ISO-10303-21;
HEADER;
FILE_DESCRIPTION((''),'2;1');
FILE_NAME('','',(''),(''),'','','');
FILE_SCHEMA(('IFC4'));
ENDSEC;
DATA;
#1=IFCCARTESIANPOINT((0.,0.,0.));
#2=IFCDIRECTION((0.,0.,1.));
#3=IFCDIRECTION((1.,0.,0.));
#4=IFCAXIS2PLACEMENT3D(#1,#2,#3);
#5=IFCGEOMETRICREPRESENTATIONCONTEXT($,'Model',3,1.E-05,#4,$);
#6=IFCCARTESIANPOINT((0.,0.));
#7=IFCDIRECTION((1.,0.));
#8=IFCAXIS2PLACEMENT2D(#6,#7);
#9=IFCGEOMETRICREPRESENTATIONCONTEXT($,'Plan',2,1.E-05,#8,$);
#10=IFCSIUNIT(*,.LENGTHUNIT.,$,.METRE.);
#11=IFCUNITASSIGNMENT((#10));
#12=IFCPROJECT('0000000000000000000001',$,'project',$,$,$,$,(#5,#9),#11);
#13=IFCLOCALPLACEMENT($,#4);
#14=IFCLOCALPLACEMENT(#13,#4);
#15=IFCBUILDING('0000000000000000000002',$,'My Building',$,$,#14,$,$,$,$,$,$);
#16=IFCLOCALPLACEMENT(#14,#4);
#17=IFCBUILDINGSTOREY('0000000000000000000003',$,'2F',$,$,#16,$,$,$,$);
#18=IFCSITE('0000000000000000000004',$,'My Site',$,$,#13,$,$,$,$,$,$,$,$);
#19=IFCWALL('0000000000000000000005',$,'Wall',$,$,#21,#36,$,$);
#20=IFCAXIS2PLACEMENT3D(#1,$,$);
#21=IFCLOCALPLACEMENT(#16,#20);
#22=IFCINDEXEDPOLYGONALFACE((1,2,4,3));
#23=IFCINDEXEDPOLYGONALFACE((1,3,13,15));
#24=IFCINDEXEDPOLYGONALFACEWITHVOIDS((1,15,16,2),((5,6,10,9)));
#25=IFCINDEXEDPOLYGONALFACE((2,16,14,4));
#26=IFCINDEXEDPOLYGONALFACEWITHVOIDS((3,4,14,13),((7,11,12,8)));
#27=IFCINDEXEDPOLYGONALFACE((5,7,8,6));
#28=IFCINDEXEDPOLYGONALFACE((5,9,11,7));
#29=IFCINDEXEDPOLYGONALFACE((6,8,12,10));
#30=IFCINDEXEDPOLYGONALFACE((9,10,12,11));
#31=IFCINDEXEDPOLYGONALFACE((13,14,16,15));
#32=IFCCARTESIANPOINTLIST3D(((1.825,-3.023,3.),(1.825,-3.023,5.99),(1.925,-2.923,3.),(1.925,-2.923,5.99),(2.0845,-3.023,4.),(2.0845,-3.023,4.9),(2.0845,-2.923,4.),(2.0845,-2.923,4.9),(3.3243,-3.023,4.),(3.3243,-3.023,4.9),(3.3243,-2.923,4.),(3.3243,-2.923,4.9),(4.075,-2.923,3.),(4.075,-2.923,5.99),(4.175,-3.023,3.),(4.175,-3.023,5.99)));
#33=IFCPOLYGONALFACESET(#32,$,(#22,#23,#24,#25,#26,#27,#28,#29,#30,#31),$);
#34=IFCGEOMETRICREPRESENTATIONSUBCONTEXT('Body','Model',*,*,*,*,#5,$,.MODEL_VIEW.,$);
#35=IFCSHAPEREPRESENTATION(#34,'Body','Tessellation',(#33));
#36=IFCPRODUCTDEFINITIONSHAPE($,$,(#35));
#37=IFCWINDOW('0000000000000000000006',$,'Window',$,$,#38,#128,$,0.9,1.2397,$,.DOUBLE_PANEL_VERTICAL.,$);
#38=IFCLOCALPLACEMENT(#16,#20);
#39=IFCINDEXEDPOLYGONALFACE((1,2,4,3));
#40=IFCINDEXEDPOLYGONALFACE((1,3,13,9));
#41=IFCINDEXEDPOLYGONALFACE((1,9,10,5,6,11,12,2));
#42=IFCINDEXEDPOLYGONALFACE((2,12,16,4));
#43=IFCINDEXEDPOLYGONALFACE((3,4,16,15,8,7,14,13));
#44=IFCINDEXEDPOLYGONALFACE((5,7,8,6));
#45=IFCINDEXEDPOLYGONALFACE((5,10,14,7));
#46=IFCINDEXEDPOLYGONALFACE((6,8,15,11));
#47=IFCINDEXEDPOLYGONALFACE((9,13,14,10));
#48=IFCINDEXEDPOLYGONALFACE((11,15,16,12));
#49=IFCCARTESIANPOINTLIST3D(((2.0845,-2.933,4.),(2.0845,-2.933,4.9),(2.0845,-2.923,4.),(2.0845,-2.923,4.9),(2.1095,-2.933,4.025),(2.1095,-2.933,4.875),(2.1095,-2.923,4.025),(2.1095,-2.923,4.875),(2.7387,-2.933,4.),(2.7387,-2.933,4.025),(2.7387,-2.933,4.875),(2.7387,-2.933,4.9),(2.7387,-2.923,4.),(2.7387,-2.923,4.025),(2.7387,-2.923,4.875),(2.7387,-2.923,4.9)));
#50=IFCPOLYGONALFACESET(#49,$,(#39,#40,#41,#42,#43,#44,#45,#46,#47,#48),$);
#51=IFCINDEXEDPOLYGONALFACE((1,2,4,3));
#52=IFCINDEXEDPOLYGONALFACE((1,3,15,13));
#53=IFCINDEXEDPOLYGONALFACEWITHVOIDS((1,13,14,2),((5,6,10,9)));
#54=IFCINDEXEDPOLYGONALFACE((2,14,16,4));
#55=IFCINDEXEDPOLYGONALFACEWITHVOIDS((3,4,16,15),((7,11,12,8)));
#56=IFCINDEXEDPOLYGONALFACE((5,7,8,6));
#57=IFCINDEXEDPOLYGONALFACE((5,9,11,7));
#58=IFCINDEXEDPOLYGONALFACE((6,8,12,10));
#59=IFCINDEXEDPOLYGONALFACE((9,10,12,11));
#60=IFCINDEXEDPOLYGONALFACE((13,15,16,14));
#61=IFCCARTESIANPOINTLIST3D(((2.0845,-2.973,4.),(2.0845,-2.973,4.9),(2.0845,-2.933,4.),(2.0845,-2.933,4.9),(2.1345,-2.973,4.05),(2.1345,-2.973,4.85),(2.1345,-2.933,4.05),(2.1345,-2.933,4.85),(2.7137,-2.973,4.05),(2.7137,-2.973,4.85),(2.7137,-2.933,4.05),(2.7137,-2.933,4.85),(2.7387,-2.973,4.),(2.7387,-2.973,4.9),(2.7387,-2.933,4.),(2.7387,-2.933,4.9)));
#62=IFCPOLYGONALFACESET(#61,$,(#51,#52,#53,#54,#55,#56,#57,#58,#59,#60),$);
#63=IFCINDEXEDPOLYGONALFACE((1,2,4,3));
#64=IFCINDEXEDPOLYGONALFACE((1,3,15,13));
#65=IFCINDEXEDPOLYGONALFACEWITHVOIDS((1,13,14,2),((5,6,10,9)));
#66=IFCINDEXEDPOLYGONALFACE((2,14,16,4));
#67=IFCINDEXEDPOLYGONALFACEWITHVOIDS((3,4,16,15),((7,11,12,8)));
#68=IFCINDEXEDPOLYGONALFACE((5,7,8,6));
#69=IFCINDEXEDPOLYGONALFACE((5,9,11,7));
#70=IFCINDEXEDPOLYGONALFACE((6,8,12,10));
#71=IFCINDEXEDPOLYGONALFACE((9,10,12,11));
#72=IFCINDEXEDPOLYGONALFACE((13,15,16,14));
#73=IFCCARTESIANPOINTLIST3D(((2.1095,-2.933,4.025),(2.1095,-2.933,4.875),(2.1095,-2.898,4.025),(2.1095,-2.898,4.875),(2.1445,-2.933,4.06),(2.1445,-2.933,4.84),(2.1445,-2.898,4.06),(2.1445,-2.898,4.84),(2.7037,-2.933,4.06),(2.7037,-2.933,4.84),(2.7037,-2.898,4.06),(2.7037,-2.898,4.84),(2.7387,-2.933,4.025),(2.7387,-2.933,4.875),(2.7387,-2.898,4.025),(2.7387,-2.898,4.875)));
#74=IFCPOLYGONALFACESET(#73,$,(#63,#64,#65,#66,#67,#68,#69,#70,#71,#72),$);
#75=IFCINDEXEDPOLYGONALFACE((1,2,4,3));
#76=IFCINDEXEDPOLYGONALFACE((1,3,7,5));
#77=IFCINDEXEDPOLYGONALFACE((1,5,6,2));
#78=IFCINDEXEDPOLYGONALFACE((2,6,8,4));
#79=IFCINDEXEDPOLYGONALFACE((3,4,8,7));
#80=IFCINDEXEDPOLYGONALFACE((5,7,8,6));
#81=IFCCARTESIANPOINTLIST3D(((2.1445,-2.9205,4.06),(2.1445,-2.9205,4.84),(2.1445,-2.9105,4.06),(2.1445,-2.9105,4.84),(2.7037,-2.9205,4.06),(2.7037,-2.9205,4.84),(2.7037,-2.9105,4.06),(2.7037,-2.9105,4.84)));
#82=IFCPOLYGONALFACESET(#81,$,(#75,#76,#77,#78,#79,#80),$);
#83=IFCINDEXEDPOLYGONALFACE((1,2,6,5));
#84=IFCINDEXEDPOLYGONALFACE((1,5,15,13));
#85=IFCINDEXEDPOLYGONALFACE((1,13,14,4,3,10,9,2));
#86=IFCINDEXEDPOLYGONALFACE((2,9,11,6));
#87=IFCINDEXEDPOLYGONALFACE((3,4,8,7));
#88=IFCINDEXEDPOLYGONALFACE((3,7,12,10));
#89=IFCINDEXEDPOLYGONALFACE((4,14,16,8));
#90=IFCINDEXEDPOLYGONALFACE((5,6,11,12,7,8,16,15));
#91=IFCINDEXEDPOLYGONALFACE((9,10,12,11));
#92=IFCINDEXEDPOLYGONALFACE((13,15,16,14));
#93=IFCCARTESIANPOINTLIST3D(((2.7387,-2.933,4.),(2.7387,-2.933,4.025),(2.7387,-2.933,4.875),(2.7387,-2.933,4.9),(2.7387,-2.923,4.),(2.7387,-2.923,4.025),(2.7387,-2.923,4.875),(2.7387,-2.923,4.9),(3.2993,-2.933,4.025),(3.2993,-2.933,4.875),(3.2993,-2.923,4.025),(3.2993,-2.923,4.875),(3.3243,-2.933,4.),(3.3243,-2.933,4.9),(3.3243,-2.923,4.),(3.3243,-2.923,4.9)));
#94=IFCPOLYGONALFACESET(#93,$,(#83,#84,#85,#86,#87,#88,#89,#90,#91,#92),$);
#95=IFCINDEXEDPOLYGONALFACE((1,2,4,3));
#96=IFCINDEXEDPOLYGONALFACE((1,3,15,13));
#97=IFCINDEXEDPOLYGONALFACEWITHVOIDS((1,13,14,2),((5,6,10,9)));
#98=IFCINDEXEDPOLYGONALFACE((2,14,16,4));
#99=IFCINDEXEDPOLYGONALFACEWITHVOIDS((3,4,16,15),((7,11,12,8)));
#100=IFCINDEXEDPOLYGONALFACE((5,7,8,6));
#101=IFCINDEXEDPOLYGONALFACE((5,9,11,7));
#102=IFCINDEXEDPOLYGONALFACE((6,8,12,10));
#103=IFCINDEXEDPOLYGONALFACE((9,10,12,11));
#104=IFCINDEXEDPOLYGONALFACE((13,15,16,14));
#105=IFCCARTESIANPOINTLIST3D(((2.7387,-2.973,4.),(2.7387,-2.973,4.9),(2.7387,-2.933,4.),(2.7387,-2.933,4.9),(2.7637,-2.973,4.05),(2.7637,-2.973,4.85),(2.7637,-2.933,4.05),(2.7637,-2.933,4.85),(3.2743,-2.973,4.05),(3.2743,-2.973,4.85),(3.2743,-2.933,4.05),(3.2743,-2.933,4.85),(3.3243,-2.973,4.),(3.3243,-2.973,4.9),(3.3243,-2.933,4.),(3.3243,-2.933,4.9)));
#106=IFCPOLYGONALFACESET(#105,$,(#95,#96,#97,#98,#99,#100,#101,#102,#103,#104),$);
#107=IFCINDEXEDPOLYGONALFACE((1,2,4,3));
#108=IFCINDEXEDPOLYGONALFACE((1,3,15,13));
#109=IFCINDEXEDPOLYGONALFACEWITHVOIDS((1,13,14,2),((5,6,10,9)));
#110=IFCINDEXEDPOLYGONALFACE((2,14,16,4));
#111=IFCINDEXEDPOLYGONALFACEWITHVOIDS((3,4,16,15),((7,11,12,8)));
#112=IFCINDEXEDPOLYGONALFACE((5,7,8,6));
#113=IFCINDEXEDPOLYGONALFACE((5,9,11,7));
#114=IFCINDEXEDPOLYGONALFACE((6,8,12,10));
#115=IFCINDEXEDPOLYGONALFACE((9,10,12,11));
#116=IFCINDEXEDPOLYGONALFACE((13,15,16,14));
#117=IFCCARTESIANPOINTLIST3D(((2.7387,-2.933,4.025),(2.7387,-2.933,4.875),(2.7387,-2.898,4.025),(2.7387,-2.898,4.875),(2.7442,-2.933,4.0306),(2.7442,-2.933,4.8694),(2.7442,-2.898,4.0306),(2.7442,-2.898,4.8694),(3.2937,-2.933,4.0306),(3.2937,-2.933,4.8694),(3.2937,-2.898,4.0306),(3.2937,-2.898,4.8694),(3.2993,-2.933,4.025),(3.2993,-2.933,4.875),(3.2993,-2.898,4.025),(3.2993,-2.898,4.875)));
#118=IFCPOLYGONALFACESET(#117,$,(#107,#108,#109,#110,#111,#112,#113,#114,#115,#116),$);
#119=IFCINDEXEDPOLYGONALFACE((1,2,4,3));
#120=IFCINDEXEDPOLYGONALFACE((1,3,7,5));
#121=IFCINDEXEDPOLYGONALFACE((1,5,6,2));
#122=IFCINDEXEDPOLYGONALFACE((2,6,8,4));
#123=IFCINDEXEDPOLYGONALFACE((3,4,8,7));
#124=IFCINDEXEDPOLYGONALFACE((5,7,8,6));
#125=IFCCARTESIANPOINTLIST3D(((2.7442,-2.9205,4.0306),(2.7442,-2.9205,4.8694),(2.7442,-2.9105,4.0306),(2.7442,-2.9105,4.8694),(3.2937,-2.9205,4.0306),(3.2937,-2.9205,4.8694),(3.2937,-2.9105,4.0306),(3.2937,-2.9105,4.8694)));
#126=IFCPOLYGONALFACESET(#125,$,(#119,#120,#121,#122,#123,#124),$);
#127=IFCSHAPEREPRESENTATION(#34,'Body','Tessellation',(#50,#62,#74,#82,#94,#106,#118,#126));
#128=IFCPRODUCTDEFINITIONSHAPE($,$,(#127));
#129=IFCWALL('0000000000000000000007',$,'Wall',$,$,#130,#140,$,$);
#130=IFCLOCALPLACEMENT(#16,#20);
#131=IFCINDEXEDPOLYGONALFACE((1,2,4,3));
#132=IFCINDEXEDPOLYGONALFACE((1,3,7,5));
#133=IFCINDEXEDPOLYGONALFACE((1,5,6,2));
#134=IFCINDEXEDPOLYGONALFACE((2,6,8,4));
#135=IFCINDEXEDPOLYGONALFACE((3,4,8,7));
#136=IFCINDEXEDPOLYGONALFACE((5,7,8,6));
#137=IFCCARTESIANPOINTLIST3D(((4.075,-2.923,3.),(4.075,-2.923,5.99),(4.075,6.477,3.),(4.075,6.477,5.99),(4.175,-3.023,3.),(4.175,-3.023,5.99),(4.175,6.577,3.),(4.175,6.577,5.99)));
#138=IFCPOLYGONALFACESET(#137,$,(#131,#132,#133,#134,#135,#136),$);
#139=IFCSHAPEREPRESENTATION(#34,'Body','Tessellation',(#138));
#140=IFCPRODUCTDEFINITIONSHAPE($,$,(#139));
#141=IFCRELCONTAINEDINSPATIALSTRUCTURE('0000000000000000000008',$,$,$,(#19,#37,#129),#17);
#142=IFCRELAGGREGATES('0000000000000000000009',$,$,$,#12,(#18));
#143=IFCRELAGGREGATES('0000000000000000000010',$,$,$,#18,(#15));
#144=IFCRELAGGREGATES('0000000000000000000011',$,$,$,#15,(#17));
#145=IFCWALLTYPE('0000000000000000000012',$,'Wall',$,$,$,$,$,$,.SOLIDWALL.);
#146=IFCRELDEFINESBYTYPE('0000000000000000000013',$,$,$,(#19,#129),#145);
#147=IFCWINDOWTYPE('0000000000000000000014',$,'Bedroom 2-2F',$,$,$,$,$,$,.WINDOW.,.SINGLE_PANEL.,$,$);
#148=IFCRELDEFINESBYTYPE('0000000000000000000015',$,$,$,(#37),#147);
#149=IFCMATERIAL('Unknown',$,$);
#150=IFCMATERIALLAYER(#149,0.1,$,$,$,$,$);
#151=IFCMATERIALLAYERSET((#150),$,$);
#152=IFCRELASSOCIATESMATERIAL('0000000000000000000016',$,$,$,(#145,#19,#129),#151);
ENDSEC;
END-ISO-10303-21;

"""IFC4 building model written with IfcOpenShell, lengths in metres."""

from ifc_helpers import new_model, entity, si_unit, frame, origin_with_axes, origin_2d_with_axis, place, context, subcontext, project, spatial, line, indexed_curve, outline, extrude, shape, source, transform, mapped, material, layer, layer_set, layer_usage, type_object, type_shapes, element, fill, save


model = new_model("IFC4")

# Units and contexts
model_context = context("Model", 3, precision=1e-05, world=origin_with_axes())
plan_context = context("Plan", 2, precision=1e-05, world=origin_2d_with_axis())
body_context_1 = subcontext(model_context, "Body", "Model", "MODEL_VIEW")
body_context_2 = subcontext(plan_context, "Body", "Plan", "PLAN_VIEW")
ifc_project = project(units=[si_unit("LENGTHUNIT", "METRE")], contexts=[model_context, plan_context])

# Site, building, storey
site_placement = place(None, origin_with_axes())
site = spatial("IfcSite", under=ifc_project, at=site_placement, Name="My Site")
building_placement = place(site_placement, origin_with_axes())
building = spatial("IfcBuilding", under=site, at=building_placement, Name="My Building")
storey_placement = place(building_placement, origin_with_axes())
storey = spatial("IfcBuildingStorey", under=building, at=storey_placement, Name="2F")

# Shared definitions
ifc_material = material(Name="Unknown")

# Shared definitions
ifc_layer_1 = layer(ifc_material, 0.1)
ifc_layer_set_1 = layer_set([ifc_layer_1])
wall_type = type_object("IfcWallType", Name="Wall", PredefinedType="SOLIDWALL", material=ifc_layer_set_1)

# Wall, opening, window
ifc_layer_usage_1 = layer_usage(ifc_layer_set_1, "AXIS2", "POSITIVE", 0.0)
wall_1_placement = place(storey_placement, frame((1.825, -3.023, 3.0), z_axis=(0.0, 0.0, 1.0), x_axis=(1.0, 0.0, 0.0)))
wall_1 = element("IfcWall", 1, at=wall_1_placement, inside=storey, type_object=wall_type, material=ifc_layer_usage_1, Name="Wall", context=body_context_1, shape_type="SweptSolid", body=[
    extrude(outline(indexed_curve([(0.0, 0.0), (0.1, 0.1), (2.25, 0.1), (2.35, 0.0)], segments=[line(1, 2, 3, 4, 1)])), origin_with_axes(), (0.0, 0.0, 1.0), 2.99),
])
shared_shape_1 = source(origin_with_axes(), body_context_1, "Body", "SweptSolid", [
    extrude(outline(indexed_curve([(0.0, 0.0), (1.2397, 0.0), (1.2397, 0.9), (0.0, 0.9)], segments=[line(1, 2, 3, 4, 1)])), frame((0.0, -0.6, 0.0), z_axis=(0.0, -1.0, 0.0), x_axis=(1.0, 0.0, 0.0)), (0.0, 0.0, -1.0), 1.2),
])
opening_1_placement = place(wall_1_placement, frame((0.2595, 0.0, 1.0), z_axis=(0.0, 0.0, 1.0), x_axis=(1.0, 0.0, 0.0)))
opening_1 = element("IfcOpeningElement", 2, at=opening_1_placement, cuts=wall_1, PredefinedType="OPENING", context=body_context_1, shape_type="MappedRepresentation", body=[
    mapped(shared_shape_1, transform((0.0, 0.0, 0.0), x_axis=(1.0, 0.0, 0.0), y_axis=(0.0, 1.0, 0.0), z_axis=(0.0, 0.0, 1.0), scale=1.0)),
])
window_type = type_object("IfcWindowType", Name="Bedroom 2-2F", PartitioningType="SINGLE_PANEL", PredefinedType="WINDOW")
shared_shape_2 = source(origin_with_axes(), body_context_1, "Body", "SweptSolid", [
    extrude(outline(indexed_curve([(0.6541, 0.0), (0.0, 0.0), (0.0, 0.9), (0.6541, 0.9), (0.6541, 0.875), (0.025, 0.875), (0.025, 0.025), (0.6541, 0.025)], segments=[line(1, 2, 3, 4, 5, 6, 7, 8, 1)])), frame((0.0, 0.09, 0.0), z_axis=(0.0, -1.0, 0.0), x_axis=(1.0, 0.0, 0.0)), (0.0, 0.0, -1.0), 0.01),
    extrude(outline(indexed_curve([(0.0, 0.0), (0.6541, 0.0), (0.6541, 0.9), (0.0, 0.9)], segments=[line(1, 2, 3, 4, 1)]), holes=[indexed_curve([(0.05, 0.05), (0.6291, 0.05), (0.6291, 0.85), (0.05, 0.85)], segments=[line(1, 2, 3, 4, 1)])]), frame((0.0, 0.05, 0.0), z_axis=(0.0, -1.0, 0.0), x_axis=(1.0, 0.0, 0.0)), (0.0, 0.0, -1.0), 0.04),
    extrude(outline(indexed_curve([(0.0, 0.0), (0.6291, 0.0), (0.6291, 0.85), (0.0, 0.85)], segments=[line(1, 2, 3, 4, 1)]), holes=[indexed_curve([(0.035, 0.035), (0.5941, 0.035), (0.5941, 0.815), (0.035, 0.815)], segments=[line(1, 2, 3, 4, 1)])]), frame((0.025, 0.09, 0.025), z_axis=(0.0, -1.0, 0.0), x_axis=(1.0, 0.0, 0.0)), (0.0, 0.0, -1.0), 0.035),
    extrude(outline(indexed_curve([(0.035, 0.035), (0.5941, 0.035), (0.5941, 0.815), (0.035, 0.815)], segments=[line(1, 2, 3, 4, 1)])), frame((0.025, 0.1025, 0.025), z_axis=(0.0, -1.0, 0.0), x_axis=(1.0, 0.0, 0.0)), (0.0, 0.0, -1.0), 0.01),
    extrude(outline(indexed_curve([(0.0, 0.9), (0.5856, 0.9), (0.5856, 0.0), (0.0, 0.0), (0.0, 0.025), (0.5606, 0.025), (0.5606, 0.875), (0.0, 0.875)], segments=[line(1, 2, 3, 4, 5, 6, 7, 8, 1)])), frame((0.6541, 0.09, 0.0), z_axis=(0.0, -1.0, 0.0), x_axis=(1.0, 0.0, 0.0)), (0.0, 0.0, -1.0), 0.01),
    extrude(outline(indexed_curve([(0.0, 0.0), (0.5856, 0.0), (0.5856, 0.9), (0.0, 0.9)], segments=[line(1, 2, 3, 4, 1)]), holes=[indexed_curve([(0.025, 0.05), (0.5356, 0.05), (0.5356, 0.85), (0.025, 0.85)], segments=[line(1, 2, 3, 4, 1)])]), frame((0.6541, 0.05, 0.0), z_axis=(0.0, -1.0, 0.0), x_axis=(1.0, 0.0, 0.0)), (0.0, 0.0, -1.0), 0.04),
    extrude(outline(indexed_curve([(0.0, 0.0), (0.5606, 0.0), (0.5606, 0.85), (0.0, 0.85)], segments=[line(1, 2, 3, 4, 1)]), holes=[indexed_curve([(0.0056, 0.0056), (0.555, 0.0056), (0.555, 0.8444), (0.0056, 0.8444)], segments=[line(1, 2, 3, 4, 1)])]), frame((0.6541, 0.09, 0.025), z_axis=(0.0, -1.0, 0.0), x_axis=(1.0, 0.0, 0.0)), (0.0, 0.0, -1.0), 0.035),
    extrude(outline(indexed_curve([(0.0056, 0.0056), (0.555, 0.0056), (0.555, 0.8444), (0.0056, 0.8444)], segments=[line(1, 2, 3, 4, 1)])), frame((0.6541, 0.1025, 0.025), z_axis=(0.0, -1.0, 0.0), x_axis=(1.0, 0.0, 0.0)), (0.0, 0.0, -1.0), 0.01),
])
shared_shape_3 = source(origin_with_axes(), body_context_2, "Body", "Curve2D", [
    entity("IfcIndexedPolyCurve", entity("IfcCartesianPointList2D", [[0.05, 0.05], [0.6291, 0.05]])),
    entity("IfcIndexedPolyCurve", entity("IfcCartesianPointList2D", [[0.0, 0.1], [0.025, 0.1], [0.025, 0.09], [0.05, 0.09], [0.05, 0.05], [0.0, 0.05]]), [entity("IfcLineIndex", [1, 2, 3, 4, 5, 6, 1])]),
    entity("IfcIndexedPolyCurve", entity("IfcCartesianPointList2D", [[0.6541, 0.1], [0.6541, 0.1], [0.6541, 0.09], [0.6291, 0.09], [0.6291, 0.05], [0.6541, 0.05]])),
    entity("IfcIndexedPolyCurve", entity("IfcCartesianPointList2D", [[0.025, 0.09], [0.06, 0.09], [0.06, 0.125], [0.025, 0.125]]), [entity("IfcLineIndex", [1, 2, 3, 4, 1])]),
    entity("IfcIndexedPolyCurve", entity("IfcCartesianPointList2D", [[0.6541, 0.09], [0.6191, 0.09], [0.6191, 0.125], [0.6541, 0.125]]), [entity("IfcLineIndex", [1, 2, 3, 4, 1])]),
    entity("IfcIndexedPolyCurve", entity("IfcCartesianPointList2D", [[0.06, 0.09], [0.6191, 0.09]])),
    entity("IfcIndexedPolyCurve", entity("IfcCartesianPointList2D", [[0.06, 0.125], [0.6191, 0.125]])),
    entity("IfcIndexedPolyCurve", entity("IfcCartesianPointList2D", [[0.06, 0.1075], [0.6191, 0.1075]])),
    entity("IfcIndexedPolyCurve", entity("IfcCartesianPointList2D", [[0.6791, 0.05], [1.1897, 0.05]])),
    entity("IfcIndexedPolyCurve", entity("IfcCartesianPointList2D", [[0.6541, 0.1], [0.6541, 0.1], [0.6541, 0.09], [0.6791, 0.09], [0.6791, 0.05], [0.6541, 0.05]])),
    entity("IfcIndexedPolyCurve", entity("IfcCartesianPointList2D", [[1.2397, 0.1], [1.2147, 0.1], [1.2147, 0.09], [1.1897, 0.09], [1.1897, 0.05], [1.2397, 0.05]]), [entity("IfcLineIndex", [1, 2, 3, 4, 5, 6, 1])]),
    entity("IfcIndexedPolyCurve", entity("IfcCartesianPointList2D", [[0.6541, 0.09], [0.6597, 0.09], [0.6597, 0.125], [0.6541, 0.125]]), [entity("IfcLineIndex", [1, 2, 3, 4, 1])]),
    entity("IfcIndexedPolyCurve", entity("IfcCartesianPointList2D", [[1.2147, 0.09], [1.2092, 0.09], [1.2092, 0.125], [1.2147, 0.125]]), [entity("IfcLineIndex", [1, 2, 3, 4, 1])]),
    entity("IfcIndexedPolyCurve", entity("IfcCartesianPointList2D", [[0.6597, 0.09], [1.2092, 0.09]])),
    entity("IfcIndexedPolyCurve", entity("IfcCartesianPointList2D", [[0.6597, 0.125], [1.2092, 0.125]])),
    entity("IfcIndexedPolyCurve", entity("IfcCartesianPointList2D", [[0.6597, 0.1075], [1.2092, 0.1075]])),
])
type_shapes(window_type, [shared_shape_2, shared_shape_3])
window_placement = place(opening_1_placement, frame((0.0, 0.0, 0.0), z_axis=(0.0, 0.0, 1.0), x_axis=(1.0, 0.0, 0.0)))
window = element("IfcWindow", 3, at=window_placement, inside=storey, type_object=window_type, Name="Window", OverallHeight=0.9, OverallWidth=1.2397, PartitioningType="DOUBLE_PANEL_VERTICAL", shapes=[
    shape(body_context_1, "Body", "MappedRepresentation", [mapped(shared_shape_2, transform((0.0, 0.0, 0.0), x_axis=(1.0, 0.0, 0.0), y_axis=(0.0, 1.0, 0.0), z_axis=(0.0, 0.0, 1.0), scale=1.0))]),
    shape(body_context_2, "Body", "MappedRepresentation", [mapped(shared_shape_3, transform((0.0, 0.0, 0.0), x_axis=(1.0, 0.0, 0.0), y_axis=(0.0, 1.0, 0.0), z_axis=(0.0, 0.0, 1.0), scale=1.0))]),
])
fill(opening_1, window)

# Wall
ifc_layer_usage_2 = layer_usage(ifc_layer_set_1, "AXIS2", "POSITIVE", 0.0)
wall_2_placement = place(storey_placement, frame((4.175, -3.023, 3.0), z_axis=(0.0, 0.0, 1.0), x_axis=(0.0, 1.0, 0.0)))
element("IfcWall", 4, at=wall_2_placement, inside=storey, type_object=wall_type, material=ifc_layer_usage_2, Name="Wall", context=body_context_1, shape_type="SweptSolid", body=[
    extrude(outline(indexed_curve([(0.0, 0.0), (0.1, 0.1), (9.5, 0.1), (9.6, 0.0)], segments=[line(1, 2, 3, 4, 1)])), origin_with_axes(), (0.0, 0.0, 1.0), 2.99),
])

save(model, "model.ifc")
